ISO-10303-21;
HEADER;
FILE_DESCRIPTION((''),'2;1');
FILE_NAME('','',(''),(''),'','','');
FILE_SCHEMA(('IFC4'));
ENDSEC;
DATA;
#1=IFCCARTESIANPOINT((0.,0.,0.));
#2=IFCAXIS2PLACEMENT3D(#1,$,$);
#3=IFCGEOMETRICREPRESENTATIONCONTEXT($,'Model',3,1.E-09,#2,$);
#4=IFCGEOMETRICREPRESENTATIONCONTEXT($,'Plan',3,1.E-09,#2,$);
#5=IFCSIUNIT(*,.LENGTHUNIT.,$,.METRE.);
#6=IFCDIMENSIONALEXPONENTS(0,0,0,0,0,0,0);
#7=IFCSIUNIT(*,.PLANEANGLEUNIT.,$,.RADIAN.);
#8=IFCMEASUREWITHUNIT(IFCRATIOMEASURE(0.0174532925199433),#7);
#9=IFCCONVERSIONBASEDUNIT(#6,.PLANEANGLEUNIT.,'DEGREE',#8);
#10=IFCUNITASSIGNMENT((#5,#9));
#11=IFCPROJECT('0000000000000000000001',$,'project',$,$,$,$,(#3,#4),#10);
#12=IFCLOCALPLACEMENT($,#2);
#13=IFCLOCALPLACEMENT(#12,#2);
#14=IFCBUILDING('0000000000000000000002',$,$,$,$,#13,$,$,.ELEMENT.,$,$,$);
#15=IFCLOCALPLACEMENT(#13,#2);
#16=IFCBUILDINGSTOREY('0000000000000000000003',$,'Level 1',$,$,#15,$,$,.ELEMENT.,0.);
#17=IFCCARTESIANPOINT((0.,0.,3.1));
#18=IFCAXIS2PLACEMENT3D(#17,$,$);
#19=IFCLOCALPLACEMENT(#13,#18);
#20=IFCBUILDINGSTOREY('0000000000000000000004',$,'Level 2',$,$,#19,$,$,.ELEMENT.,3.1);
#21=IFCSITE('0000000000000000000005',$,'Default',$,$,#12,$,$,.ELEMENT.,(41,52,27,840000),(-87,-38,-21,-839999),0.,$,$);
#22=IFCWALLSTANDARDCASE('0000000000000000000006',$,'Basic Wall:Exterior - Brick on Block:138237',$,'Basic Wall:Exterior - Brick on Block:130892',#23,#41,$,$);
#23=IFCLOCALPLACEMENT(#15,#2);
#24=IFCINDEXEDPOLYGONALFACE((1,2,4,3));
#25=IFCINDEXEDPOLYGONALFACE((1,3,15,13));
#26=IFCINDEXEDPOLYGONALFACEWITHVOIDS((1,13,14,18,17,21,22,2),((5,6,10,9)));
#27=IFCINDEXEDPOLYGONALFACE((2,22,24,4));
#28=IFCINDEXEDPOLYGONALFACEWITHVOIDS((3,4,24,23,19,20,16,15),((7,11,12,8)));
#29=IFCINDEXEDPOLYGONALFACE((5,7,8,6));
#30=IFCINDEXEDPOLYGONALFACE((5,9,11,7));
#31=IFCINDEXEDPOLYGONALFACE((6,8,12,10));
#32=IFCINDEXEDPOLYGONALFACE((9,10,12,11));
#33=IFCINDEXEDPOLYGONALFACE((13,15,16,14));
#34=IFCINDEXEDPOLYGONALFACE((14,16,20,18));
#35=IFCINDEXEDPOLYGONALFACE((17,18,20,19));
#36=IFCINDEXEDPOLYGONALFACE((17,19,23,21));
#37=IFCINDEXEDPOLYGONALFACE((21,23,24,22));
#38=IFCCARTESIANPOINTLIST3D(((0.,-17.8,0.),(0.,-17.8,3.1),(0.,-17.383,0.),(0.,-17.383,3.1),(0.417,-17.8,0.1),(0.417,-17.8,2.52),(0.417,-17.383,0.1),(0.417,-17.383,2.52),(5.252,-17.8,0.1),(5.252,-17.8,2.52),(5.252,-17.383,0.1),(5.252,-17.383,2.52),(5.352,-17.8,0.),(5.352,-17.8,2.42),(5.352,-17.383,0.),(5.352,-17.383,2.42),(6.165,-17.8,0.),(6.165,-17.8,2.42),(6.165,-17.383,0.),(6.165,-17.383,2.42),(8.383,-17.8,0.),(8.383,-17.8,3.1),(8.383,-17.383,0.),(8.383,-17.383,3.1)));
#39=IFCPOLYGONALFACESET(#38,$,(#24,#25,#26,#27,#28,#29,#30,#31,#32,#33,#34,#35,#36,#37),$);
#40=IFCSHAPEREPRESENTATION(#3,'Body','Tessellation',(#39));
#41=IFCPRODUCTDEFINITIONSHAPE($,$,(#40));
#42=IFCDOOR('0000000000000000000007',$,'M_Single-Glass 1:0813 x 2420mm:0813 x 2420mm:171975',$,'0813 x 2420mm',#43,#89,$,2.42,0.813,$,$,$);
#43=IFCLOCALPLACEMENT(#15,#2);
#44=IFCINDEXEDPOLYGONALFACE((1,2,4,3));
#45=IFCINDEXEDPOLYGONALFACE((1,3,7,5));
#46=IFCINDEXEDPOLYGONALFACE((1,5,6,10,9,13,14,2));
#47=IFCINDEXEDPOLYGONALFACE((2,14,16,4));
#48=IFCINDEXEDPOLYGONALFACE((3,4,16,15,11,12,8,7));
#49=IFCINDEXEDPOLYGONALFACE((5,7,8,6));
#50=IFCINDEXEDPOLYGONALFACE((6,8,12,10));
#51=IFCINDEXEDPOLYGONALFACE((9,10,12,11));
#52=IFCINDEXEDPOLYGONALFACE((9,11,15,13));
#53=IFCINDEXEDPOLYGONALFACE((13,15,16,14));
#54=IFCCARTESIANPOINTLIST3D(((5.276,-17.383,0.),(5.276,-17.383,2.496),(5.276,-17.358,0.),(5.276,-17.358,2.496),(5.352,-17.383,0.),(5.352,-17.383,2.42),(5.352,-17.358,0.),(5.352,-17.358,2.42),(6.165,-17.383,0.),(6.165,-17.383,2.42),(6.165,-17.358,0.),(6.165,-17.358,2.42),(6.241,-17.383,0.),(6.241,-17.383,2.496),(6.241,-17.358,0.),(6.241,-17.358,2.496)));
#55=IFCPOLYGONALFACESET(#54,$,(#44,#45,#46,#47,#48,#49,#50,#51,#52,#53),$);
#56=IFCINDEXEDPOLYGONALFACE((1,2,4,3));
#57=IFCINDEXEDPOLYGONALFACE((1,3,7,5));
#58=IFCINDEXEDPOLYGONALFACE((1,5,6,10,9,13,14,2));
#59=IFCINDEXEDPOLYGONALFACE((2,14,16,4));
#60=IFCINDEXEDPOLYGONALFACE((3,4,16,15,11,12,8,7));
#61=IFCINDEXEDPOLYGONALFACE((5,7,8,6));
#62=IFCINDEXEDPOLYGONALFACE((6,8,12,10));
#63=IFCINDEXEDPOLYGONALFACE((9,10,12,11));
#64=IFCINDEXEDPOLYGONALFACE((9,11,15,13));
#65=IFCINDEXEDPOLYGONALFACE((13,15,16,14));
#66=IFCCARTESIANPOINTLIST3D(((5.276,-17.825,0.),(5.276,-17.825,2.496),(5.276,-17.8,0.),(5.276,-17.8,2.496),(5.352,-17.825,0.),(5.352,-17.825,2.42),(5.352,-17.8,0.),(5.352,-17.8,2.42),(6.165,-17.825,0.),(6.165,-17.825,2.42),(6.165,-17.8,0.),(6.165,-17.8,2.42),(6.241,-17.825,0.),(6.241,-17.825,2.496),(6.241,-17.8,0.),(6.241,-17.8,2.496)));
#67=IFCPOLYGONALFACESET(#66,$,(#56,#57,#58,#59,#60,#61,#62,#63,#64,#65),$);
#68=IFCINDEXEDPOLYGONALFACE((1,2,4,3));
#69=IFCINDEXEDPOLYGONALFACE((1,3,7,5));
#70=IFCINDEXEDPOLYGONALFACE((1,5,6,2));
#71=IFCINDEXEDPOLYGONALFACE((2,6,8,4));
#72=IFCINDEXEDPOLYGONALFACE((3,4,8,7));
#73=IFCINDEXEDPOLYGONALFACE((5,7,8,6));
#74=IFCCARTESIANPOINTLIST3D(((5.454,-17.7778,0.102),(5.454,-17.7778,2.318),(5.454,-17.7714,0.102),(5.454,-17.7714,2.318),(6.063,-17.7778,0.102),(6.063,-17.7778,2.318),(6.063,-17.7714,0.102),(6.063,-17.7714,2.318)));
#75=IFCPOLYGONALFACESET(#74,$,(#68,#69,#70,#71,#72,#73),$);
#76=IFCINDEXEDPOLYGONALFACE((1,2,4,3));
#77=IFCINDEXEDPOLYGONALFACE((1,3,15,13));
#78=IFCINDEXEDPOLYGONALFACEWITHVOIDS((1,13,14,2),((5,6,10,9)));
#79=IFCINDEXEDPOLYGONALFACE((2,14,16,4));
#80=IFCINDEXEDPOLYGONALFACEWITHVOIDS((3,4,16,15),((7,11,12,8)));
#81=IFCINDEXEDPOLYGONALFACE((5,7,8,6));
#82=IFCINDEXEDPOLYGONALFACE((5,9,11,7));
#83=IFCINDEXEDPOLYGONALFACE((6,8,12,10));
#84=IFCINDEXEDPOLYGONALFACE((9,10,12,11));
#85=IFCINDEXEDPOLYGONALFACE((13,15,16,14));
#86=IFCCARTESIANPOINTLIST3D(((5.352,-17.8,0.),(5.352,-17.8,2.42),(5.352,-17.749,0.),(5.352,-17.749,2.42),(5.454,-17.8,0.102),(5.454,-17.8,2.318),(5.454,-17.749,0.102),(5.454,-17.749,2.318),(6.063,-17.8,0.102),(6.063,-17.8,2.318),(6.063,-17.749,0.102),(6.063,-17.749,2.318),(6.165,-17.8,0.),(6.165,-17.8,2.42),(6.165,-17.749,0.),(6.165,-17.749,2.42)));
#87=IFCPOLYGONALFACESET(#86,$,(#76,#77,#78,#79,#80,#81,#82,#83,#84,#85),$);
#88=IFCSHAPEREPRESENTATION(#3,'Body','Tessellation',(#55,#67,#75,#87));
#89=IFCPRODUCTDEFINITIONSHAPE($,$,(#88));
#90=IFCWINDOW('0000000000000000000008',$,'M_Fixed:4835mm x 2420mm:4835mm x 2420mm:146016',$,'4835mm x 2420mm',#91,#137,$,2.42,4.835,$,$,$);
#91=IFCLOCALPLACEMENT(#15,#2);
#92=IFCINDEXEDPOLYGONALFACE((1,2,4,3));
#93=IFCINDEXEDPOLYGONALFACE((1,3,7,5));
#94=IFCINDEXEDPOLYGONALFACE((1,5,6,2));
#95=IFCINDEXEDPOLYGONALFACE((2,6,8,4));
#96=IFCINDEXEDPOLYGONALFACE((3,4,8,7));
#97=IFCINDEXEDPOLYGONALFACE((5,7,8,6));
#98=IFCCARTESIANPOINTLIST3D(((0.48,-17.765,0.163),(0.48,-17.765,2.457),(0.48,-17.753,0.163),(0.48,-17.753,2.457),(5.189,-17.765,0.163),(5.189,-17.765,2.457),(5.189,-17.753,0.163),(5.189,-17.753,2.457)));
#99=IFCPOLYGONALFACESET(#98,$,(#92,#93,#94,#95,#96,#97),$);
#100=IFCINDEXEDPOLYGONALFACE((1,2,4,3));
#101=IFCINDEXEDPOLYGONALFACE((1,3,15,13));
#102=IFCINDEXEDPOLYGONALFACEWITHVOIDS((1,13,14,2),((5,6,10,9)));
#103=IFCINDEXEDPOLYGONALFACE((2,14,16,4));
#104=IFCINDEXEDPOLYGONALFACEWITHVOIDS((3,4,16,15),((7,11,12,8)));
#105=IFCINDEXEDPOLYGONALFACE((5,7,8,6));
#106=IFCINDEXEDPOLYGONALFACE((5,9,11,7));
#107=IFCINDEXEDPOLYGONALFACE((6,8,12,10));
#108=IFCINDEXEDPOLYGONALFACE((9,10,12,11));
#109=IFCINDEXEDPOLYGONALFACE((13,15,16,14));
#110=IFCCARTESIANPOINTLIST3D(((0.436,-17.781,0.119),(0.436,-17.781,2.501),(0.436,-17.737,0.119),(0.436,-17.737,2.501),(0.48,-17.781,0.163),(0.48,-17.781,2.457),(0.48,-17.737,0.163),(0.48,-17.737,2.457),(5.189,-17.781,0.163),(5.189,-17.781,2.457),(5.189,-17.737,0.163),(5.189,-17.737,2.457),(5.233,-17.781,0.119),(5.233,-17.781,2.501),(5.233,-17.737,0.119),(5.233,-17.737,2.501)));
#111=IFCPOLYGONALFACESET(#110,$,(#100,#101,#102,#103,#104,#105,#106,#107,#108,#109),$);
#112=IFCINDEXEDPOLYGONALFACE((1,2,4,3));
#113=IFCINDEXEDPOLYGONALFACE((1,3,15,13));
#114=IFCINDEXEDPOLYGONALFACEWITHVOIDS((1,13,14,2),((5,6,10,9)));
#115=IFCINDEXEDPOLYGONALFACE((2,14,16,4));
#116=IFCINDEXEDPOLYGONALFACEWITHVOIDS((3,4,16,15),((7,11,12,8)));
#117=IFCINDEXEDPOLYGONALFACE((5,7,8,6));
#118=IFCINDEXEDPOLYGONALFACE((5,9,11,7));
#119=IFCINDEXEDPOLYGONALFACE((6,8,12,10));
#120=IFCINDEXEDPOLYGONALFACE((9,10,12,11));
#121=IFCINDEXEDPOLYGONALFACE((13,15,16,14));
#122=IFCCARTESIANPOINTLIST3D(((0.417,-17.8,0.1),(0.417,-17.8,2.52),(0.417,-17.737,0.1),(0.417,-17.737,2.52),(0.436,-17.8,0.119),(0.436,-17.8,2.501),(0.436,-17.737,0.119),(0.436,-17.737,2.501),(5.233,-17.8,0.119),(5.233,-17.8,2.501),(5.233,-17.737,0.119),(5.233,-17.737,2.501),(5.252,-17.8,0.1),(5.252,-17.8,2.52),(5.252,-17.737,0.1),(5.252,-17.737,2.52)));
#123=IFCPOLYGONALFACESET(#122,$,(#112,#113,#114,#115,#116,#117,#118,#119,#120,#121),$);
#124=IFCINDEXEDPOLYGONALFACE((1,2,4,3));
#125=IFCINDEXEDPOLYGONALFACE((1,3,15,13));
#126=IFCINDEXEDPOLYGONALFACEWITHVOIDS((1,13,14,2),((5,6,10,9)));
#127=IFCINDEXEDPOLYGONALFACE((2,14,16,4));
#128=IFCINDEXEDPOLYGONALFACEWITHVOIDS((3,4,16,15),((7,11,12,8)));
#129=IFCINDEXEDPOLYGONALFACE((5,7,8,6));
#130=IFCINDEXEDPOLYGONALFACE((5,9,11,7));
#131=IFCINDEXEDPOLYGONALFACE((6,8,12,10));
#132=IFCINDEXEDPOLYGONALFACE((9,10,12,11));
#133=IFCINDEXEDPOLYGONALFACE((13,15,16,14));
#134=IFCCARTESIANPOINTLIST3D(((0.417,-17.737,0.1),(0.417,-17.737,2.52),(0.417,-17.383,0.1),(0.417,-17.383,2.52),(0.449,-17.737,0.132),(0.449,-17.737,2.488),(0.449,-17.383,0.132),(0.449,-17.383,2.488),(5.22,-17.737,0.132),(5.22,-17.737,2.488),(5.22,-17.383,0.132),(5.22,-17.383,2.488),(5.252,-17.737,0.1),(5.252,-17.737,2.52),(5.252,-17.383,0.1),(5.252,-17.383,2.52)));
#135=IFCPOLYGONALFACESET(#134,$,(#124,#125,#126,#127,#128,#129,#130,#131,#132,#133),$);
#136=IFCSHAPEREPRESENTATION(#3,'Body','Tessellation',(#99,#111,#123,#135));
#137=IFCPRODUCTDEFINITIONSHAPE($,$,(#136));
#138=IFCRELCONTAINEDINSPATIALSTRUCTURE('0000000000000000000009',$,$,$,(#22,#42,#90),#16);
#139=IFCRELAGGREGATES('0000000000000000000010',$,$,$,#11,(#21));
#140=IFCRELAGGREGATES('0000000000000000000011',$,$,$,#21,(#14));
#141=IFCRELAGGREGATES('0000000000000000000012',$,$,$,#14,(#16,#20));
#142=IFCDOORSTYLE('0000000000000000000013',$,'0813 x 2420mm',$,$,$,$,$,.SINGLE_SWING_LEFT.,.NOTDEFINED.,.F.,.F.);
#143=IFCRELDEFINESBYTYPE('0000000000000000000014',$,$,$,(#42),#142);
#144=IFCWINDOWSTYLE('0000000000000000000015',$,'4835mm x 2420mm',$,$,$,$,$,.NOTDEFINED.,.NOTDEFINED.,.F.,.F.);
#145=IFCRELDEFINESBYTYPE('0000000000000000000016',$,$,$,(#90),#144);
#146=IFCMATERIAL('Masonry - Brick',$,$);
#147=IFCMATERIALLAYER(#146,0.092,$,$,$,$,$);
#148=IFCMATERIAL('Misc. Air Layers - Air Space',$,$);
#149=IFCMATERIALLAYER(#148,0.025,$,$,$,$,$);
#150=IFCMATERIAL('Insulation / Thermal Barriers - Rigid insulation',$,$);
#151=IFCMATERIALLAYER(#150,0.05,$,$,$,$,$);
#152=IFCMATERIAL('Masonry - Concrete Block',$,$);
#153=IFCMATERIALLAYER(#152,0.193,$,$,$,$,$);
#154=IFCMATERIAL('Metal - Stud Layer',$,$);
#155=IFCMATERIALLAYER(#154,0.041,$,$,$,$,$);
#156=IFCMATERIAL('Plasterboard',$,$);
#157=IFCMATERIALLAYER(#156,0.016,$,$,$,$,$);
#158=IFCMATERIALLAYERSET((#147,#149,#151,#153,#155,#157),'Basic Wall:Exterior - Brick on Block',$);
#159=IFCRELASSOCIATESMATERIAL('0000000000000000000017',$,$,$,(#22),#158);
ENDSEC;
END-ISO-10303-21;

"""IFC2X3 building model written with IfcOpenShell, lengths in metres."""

from ifc_helpers import new_model, entity, si_unit, converted_unit, frame, frame_2d, origin, origin_2d_with_axis, place, context, project, spatial, polyline, rectangle, outline, extrude, source, transform, mapped, material, layer, layer_set, layer_usage, type_object, type_shapes, element, fill, save


model = new_model("IFC2X3")

# Units and contexts
model_context = context("Model", 3, precision=1e-09, world=origin())
plan_context = context("Plan", 3, precision=1e-09, world=origin())
ifc_project = project(units=[si_unit("LENGTHUNIT", "METRE"), converted_unit("PLANEANGLEUNIT", "DEGREE", entity("IfcRatioMeasure", 0.0174532925199433), si_unit("PLANEANGLEUNIT", "RADIAN"), dimensions=[0, 0, 0, 0, 0, 0, 0])], contexts=[model_context, plan_context])

# Site, building, storey
site_placement = place(None, origin())
site = spatial("IfcSite", under=ifc_project, at=site_placement, Name="Default", CompositionType="ELEMENT", RefLatitude=(41, 52, 27, 840000), RefLongitude=(-87, -38, -21, -839999), RefElevation=0.0)
building_placement = place(site_placement, origin())
building = spatial("IfcBuilding", under=site, at=building_placement, CompositionType="ELEMENT")
storey_1_placement = place(building_placement, origin())
storey_1 = spatial("IfcBuildingStorey", under=building, at=storey_1_placement, Name="Level 1", CompositionType="ELEMENT", Elevation=0.0)

# Shared definitions
ifc_material_1 = material(Name="Masonry - Brick")
ifc_layer_1 = layer(ifc_material_1, 0.092)
ifc_material_2 = material(Name="Misc. Air Layers - Air Space")
ifc_layer_2 = layer(ifc_material_2, 0.025)
ifc_material_3 = material(Name="Insulation / Thermal Barriers - Rigid insulation")
ifc_layer_3 = layer(ifc_material_3, 0.05)
ifc_material_4 = material(Name="Masonry - Concrete Block")
ifc_layer_4 = layer(ifc_material_4, 0.193)
ifc_material_5 = material(Name="Metal - Stud Layer")
ifc_layer_5 = layer(ifc_material_5, 0.041)
ifc_material_6 = material(Name="Plasterboard")
ifc_layer_6 = layer(ifc_material_6, 0.016)
ifc_layer_set_1 = layer_set([ifc_layer_1, ifc_layer_2, ifc_layer_3, ifc_layer_4, ifc_layer_5, ifc_layer_6], Name="Basic Wall:Exterior - Brick on Block")
ifc_layer_usage_1 = layer_usage(ifc_layer_set_1, "AXIS2", "NEGATIVE", 0.2085)

# Shared definitions
storey_2_placement = place(building_placement, frame((0.0, 0.0, 3.1)))
storey_2 = spatial("IfcBuildingStorey", under=building, at=storey_2_placement, Name="Level 2", CompositionType="ELEMENT", Elevation=3.1)

# Wall, openings, door, window
wall_1_placement = place(storey_1_placement, frame((8.383, -17.5915, 0.0), z_axis=(0.0, 0.0, 1.0), x_axis=(-1.0, 0.0, 0.0)))
wall_1 = element("IfcWallStandardCase", 1, at=wall_1_placement, inside=storey_1, material=ifc_layer_usage_1, Name="Basic Wall:Exterior - Brick on Block:138237", ObjectType="Basic Wall:Exterior - Brick on Block:130892", context=model_context, shape_type="SweptSolid", body=[
    extrude(rectangle(XDim=8.383, YDim=0.417, at=frame_2d((4.1915, 0.0), x_axis=(-1.0, 0.0))), origin(), (0.0, 0.0, 1.0), 3.1),
])
opening_1_placement = place(wall_1_placement, frame((3.131, -0.2085, 0.1)))
opening_1 = element("IfcOpeningElement", 2, at=opening_1_placement, cuts=wall_1, ObjectType="Opening", context=model_context, shape_type="SweptSolid", body=[
    extrude(rectangle(XDim=2.42, YDim=4.835, at=frame_2d((1.21, 2.4175), x_axis=(1.0, 0.0))), frame((0.0, 0.0, 0.0), z_axis=(0.0, 1.0, 0.0), x_axis=(0.0, 0.0, 1.0)), (0.0, 0.0, 1.0), 0.417),
])
opening_2_placement = place(wall_1_placement, frame((2.218, -0.2085, 0.0)))
opening_2 = element("IfcOpeningElement", 3, at=opening_2_placement, cuts=wall_1, ObjectType="Opening", context=model_context, shape_type="SweptSolid", body=[
    extrude(rectangle(XDim=0.813, YDim=2.42, at=frame_2d((1.21, 0.4065), x_axis=(0.0, -1.0))), frame((0.0, 0.0, 0.0), z_axis=(0.0, 1.0, 0.0), x_axis=(0.0, 0.0, 1.0)), (0.0, 0.0, 1.0), 0.417),
])
door_style_1 = type_object("IfcDoorStyle", Name="0813 x 2420mm", ConstructionType="NOTDEFINED", OperationType="SINGLE_SWING_LEFT", ParameterTakesPrecedence=False, Sizeable=False)
shared_shape_1 = source(origin(), model_context, "Body", "SweptSolid", [
    extrude(outline(polyline([(-0.4065, -1.191), (-0.4065, 1.229), (-0.4825, 1.229), (-0.4825, -1.267), (0.4825, -1.267), (0.4825, 1.229), (0.4065, 1.229), (0.4065, -1.191), (-0.4065, -1.191)])), frame((0.4065, 0.0, 1.229), z_axis=(0.0, 1.0, 0.0), x_axis=(1.0, 0.0, 0.0)), (0.0, 0.0, -1.0), 0.025),
    extrude(outline(polyline([(-0.4065, -1.191), (-0.4065, 1.229), (-0.4825, 1.229), (-0.4825, -1.267), (0.4825, -1.267), (0.4825, 1.229), (0.4065, 1.229), (0.4065, -1.191), (-0.4065, -1.191)])), frame((0.4065, 0.442, 1.229), z_axis=(0.0, 1.0, 0.0), x_axis=(1.0, 0.0, 0.0)), (0.0, 0.0, -1.0), 0.025),
    extrude(rectangle(XDim=0.609, YDim=0.0064, at=origin_2d_with_axis()), frame((0.4065, 0.3916, 0.102)), (0.0, 0.0, 1.0), 2.216),
    extrude(outline(polyline([(-1.21, -0.4065), (1.21, -0.4065), (1.21, 0.4065), (-1.21, 0.4065), (-1.21, -0.4065)]), holes=[polyline([(-1.108, 0.3045), (1.108, 0.3045), (1.108, -0.3045), (-1.108, -0.3045), (-1.108, 0.3045)])]), frame((0.4065, 0.417, 1.21), z_axis=(0.0, -1.0, 0.0), x_axis=(0.0, 0.0, -1.0)), (0.0, 0.0, 1.0), 0.051),
])
type_shapes(door_style_1, [shared_shape_1])
door_1_placement = place(opening_2_placement, origin())
door_1 = element("IfcDoor", 4, at=door_1_placement, inside=storey_1, type_object=door_style_1, Name="M_Single-Glass 1:0813 x 2420mm:0813 x 2420mm:171975", ObjectType="0813 x 2420mm", OverallHeight=2.42, OverallWidth=0.813, context=model_context, shape_type="MappedRepresentation", body=[
    mapped(shared_shape_1, transform((0.0, 0.0, 0.0), scale=1.0)),
])
fill(opening_2, door_1)
window_style_1 = type_object("IfcWindowStyle", Name="4835mm x 2420mm", ConstructionType="NOTDEFINED", OperationType="NOTDEFINED", ParameterTakesPrecedence=False, Sizeable=False)
shared_shape_2 = source(origin(), model_context, "Body", "SweptSolid", [
    extrude(rectangle(XDim=0.012, YDim=4.709, at=origin_2d_with_axis()), frame((2.4175, 0.376, 0.063), z_axis=(0.0, 0.0, 1.0), x_axis=(0.0, -1.0, 0.0)), (0.0, 0.0, 1.0), 2.294),
    extrude(outline(polyline([(-2.3985, -1.191), (2.3985, -1.191), (2.3985, 1.191), (-2.3985, 1.191), (-2.3985, -1.191)]), holes=[polyline([(-2.3545, -1.147), (-2.3545, 1.147), (2.3545, 1.147), (2.3545, -1.147), (-2.3545, -1.147)])]), frame((2.4175, 0.354, 1.21), z_axis=(0.0, 1.0, 0.0), x_axis=(1.0, 0.0, 0.0)), (0.0, 0.0, 1.0), 0.044),
    extrude(outline(polyline([(-2.4175, -1.21), (2.4175, -1.21), (2.4175, 1.21), (-2.4175, 1.21), (-2.4175, -1.21)]), holes=[polyline([(-2.3985, -1.191), (-2.3985, 1.191), (2.3985, 1.191), (2.3985, -1.191), (-2.3985, -1.191)])]), frame((2.4175, 0.354, 1.21), z_axis=(0.0, 1.0, 0.0), x_axis=(1.0, 0.0, 0.0)), (0.0, 0.0, 1.0), 0.063),
    extrude(outline(polyline([(-2.4175, -1.21), (2.4175, -1.21), (2.4175, 1.21), (-2.4175, 1.21), (-2.4175, -1.21)]), holes=[polyline([(-2.3855, -1.178), (-2.3855, 1.178), (2.3855, 1.178), (2.3855, -1.178), (-2.3855, -1.178)])]), frame((2.4175, 0.0, 1.21), z_axis=(0.0, 1.0, 0.0), x_axis=(1.0, 0.0, 0.0)), (0.0, 0.0, 1.0), 0.354),
])
type_shapes(window_style_1, [shared_shape_2])
window_1_placement = place(opening_1_placement, origin())
window_1 = element("IfcWindow", 5, at=window_1_placement, inside=storey_1, type_object=window_style_1, Name="M_Fixed:4835mm x 2420mm:4835mm x 2420mm:146016", ObjectType="4835mm x 2420mm", OverallHeight=2.42, OverallWidth=4.835, context=model_context, shape_type="MappedRepresentation", body=[
    mapped(shared_shape_2, transform((0.0, 0.0, 0.0), scale=1.0)),
])
fill(opening_1, window_1)

save(model, "model.ifc")
